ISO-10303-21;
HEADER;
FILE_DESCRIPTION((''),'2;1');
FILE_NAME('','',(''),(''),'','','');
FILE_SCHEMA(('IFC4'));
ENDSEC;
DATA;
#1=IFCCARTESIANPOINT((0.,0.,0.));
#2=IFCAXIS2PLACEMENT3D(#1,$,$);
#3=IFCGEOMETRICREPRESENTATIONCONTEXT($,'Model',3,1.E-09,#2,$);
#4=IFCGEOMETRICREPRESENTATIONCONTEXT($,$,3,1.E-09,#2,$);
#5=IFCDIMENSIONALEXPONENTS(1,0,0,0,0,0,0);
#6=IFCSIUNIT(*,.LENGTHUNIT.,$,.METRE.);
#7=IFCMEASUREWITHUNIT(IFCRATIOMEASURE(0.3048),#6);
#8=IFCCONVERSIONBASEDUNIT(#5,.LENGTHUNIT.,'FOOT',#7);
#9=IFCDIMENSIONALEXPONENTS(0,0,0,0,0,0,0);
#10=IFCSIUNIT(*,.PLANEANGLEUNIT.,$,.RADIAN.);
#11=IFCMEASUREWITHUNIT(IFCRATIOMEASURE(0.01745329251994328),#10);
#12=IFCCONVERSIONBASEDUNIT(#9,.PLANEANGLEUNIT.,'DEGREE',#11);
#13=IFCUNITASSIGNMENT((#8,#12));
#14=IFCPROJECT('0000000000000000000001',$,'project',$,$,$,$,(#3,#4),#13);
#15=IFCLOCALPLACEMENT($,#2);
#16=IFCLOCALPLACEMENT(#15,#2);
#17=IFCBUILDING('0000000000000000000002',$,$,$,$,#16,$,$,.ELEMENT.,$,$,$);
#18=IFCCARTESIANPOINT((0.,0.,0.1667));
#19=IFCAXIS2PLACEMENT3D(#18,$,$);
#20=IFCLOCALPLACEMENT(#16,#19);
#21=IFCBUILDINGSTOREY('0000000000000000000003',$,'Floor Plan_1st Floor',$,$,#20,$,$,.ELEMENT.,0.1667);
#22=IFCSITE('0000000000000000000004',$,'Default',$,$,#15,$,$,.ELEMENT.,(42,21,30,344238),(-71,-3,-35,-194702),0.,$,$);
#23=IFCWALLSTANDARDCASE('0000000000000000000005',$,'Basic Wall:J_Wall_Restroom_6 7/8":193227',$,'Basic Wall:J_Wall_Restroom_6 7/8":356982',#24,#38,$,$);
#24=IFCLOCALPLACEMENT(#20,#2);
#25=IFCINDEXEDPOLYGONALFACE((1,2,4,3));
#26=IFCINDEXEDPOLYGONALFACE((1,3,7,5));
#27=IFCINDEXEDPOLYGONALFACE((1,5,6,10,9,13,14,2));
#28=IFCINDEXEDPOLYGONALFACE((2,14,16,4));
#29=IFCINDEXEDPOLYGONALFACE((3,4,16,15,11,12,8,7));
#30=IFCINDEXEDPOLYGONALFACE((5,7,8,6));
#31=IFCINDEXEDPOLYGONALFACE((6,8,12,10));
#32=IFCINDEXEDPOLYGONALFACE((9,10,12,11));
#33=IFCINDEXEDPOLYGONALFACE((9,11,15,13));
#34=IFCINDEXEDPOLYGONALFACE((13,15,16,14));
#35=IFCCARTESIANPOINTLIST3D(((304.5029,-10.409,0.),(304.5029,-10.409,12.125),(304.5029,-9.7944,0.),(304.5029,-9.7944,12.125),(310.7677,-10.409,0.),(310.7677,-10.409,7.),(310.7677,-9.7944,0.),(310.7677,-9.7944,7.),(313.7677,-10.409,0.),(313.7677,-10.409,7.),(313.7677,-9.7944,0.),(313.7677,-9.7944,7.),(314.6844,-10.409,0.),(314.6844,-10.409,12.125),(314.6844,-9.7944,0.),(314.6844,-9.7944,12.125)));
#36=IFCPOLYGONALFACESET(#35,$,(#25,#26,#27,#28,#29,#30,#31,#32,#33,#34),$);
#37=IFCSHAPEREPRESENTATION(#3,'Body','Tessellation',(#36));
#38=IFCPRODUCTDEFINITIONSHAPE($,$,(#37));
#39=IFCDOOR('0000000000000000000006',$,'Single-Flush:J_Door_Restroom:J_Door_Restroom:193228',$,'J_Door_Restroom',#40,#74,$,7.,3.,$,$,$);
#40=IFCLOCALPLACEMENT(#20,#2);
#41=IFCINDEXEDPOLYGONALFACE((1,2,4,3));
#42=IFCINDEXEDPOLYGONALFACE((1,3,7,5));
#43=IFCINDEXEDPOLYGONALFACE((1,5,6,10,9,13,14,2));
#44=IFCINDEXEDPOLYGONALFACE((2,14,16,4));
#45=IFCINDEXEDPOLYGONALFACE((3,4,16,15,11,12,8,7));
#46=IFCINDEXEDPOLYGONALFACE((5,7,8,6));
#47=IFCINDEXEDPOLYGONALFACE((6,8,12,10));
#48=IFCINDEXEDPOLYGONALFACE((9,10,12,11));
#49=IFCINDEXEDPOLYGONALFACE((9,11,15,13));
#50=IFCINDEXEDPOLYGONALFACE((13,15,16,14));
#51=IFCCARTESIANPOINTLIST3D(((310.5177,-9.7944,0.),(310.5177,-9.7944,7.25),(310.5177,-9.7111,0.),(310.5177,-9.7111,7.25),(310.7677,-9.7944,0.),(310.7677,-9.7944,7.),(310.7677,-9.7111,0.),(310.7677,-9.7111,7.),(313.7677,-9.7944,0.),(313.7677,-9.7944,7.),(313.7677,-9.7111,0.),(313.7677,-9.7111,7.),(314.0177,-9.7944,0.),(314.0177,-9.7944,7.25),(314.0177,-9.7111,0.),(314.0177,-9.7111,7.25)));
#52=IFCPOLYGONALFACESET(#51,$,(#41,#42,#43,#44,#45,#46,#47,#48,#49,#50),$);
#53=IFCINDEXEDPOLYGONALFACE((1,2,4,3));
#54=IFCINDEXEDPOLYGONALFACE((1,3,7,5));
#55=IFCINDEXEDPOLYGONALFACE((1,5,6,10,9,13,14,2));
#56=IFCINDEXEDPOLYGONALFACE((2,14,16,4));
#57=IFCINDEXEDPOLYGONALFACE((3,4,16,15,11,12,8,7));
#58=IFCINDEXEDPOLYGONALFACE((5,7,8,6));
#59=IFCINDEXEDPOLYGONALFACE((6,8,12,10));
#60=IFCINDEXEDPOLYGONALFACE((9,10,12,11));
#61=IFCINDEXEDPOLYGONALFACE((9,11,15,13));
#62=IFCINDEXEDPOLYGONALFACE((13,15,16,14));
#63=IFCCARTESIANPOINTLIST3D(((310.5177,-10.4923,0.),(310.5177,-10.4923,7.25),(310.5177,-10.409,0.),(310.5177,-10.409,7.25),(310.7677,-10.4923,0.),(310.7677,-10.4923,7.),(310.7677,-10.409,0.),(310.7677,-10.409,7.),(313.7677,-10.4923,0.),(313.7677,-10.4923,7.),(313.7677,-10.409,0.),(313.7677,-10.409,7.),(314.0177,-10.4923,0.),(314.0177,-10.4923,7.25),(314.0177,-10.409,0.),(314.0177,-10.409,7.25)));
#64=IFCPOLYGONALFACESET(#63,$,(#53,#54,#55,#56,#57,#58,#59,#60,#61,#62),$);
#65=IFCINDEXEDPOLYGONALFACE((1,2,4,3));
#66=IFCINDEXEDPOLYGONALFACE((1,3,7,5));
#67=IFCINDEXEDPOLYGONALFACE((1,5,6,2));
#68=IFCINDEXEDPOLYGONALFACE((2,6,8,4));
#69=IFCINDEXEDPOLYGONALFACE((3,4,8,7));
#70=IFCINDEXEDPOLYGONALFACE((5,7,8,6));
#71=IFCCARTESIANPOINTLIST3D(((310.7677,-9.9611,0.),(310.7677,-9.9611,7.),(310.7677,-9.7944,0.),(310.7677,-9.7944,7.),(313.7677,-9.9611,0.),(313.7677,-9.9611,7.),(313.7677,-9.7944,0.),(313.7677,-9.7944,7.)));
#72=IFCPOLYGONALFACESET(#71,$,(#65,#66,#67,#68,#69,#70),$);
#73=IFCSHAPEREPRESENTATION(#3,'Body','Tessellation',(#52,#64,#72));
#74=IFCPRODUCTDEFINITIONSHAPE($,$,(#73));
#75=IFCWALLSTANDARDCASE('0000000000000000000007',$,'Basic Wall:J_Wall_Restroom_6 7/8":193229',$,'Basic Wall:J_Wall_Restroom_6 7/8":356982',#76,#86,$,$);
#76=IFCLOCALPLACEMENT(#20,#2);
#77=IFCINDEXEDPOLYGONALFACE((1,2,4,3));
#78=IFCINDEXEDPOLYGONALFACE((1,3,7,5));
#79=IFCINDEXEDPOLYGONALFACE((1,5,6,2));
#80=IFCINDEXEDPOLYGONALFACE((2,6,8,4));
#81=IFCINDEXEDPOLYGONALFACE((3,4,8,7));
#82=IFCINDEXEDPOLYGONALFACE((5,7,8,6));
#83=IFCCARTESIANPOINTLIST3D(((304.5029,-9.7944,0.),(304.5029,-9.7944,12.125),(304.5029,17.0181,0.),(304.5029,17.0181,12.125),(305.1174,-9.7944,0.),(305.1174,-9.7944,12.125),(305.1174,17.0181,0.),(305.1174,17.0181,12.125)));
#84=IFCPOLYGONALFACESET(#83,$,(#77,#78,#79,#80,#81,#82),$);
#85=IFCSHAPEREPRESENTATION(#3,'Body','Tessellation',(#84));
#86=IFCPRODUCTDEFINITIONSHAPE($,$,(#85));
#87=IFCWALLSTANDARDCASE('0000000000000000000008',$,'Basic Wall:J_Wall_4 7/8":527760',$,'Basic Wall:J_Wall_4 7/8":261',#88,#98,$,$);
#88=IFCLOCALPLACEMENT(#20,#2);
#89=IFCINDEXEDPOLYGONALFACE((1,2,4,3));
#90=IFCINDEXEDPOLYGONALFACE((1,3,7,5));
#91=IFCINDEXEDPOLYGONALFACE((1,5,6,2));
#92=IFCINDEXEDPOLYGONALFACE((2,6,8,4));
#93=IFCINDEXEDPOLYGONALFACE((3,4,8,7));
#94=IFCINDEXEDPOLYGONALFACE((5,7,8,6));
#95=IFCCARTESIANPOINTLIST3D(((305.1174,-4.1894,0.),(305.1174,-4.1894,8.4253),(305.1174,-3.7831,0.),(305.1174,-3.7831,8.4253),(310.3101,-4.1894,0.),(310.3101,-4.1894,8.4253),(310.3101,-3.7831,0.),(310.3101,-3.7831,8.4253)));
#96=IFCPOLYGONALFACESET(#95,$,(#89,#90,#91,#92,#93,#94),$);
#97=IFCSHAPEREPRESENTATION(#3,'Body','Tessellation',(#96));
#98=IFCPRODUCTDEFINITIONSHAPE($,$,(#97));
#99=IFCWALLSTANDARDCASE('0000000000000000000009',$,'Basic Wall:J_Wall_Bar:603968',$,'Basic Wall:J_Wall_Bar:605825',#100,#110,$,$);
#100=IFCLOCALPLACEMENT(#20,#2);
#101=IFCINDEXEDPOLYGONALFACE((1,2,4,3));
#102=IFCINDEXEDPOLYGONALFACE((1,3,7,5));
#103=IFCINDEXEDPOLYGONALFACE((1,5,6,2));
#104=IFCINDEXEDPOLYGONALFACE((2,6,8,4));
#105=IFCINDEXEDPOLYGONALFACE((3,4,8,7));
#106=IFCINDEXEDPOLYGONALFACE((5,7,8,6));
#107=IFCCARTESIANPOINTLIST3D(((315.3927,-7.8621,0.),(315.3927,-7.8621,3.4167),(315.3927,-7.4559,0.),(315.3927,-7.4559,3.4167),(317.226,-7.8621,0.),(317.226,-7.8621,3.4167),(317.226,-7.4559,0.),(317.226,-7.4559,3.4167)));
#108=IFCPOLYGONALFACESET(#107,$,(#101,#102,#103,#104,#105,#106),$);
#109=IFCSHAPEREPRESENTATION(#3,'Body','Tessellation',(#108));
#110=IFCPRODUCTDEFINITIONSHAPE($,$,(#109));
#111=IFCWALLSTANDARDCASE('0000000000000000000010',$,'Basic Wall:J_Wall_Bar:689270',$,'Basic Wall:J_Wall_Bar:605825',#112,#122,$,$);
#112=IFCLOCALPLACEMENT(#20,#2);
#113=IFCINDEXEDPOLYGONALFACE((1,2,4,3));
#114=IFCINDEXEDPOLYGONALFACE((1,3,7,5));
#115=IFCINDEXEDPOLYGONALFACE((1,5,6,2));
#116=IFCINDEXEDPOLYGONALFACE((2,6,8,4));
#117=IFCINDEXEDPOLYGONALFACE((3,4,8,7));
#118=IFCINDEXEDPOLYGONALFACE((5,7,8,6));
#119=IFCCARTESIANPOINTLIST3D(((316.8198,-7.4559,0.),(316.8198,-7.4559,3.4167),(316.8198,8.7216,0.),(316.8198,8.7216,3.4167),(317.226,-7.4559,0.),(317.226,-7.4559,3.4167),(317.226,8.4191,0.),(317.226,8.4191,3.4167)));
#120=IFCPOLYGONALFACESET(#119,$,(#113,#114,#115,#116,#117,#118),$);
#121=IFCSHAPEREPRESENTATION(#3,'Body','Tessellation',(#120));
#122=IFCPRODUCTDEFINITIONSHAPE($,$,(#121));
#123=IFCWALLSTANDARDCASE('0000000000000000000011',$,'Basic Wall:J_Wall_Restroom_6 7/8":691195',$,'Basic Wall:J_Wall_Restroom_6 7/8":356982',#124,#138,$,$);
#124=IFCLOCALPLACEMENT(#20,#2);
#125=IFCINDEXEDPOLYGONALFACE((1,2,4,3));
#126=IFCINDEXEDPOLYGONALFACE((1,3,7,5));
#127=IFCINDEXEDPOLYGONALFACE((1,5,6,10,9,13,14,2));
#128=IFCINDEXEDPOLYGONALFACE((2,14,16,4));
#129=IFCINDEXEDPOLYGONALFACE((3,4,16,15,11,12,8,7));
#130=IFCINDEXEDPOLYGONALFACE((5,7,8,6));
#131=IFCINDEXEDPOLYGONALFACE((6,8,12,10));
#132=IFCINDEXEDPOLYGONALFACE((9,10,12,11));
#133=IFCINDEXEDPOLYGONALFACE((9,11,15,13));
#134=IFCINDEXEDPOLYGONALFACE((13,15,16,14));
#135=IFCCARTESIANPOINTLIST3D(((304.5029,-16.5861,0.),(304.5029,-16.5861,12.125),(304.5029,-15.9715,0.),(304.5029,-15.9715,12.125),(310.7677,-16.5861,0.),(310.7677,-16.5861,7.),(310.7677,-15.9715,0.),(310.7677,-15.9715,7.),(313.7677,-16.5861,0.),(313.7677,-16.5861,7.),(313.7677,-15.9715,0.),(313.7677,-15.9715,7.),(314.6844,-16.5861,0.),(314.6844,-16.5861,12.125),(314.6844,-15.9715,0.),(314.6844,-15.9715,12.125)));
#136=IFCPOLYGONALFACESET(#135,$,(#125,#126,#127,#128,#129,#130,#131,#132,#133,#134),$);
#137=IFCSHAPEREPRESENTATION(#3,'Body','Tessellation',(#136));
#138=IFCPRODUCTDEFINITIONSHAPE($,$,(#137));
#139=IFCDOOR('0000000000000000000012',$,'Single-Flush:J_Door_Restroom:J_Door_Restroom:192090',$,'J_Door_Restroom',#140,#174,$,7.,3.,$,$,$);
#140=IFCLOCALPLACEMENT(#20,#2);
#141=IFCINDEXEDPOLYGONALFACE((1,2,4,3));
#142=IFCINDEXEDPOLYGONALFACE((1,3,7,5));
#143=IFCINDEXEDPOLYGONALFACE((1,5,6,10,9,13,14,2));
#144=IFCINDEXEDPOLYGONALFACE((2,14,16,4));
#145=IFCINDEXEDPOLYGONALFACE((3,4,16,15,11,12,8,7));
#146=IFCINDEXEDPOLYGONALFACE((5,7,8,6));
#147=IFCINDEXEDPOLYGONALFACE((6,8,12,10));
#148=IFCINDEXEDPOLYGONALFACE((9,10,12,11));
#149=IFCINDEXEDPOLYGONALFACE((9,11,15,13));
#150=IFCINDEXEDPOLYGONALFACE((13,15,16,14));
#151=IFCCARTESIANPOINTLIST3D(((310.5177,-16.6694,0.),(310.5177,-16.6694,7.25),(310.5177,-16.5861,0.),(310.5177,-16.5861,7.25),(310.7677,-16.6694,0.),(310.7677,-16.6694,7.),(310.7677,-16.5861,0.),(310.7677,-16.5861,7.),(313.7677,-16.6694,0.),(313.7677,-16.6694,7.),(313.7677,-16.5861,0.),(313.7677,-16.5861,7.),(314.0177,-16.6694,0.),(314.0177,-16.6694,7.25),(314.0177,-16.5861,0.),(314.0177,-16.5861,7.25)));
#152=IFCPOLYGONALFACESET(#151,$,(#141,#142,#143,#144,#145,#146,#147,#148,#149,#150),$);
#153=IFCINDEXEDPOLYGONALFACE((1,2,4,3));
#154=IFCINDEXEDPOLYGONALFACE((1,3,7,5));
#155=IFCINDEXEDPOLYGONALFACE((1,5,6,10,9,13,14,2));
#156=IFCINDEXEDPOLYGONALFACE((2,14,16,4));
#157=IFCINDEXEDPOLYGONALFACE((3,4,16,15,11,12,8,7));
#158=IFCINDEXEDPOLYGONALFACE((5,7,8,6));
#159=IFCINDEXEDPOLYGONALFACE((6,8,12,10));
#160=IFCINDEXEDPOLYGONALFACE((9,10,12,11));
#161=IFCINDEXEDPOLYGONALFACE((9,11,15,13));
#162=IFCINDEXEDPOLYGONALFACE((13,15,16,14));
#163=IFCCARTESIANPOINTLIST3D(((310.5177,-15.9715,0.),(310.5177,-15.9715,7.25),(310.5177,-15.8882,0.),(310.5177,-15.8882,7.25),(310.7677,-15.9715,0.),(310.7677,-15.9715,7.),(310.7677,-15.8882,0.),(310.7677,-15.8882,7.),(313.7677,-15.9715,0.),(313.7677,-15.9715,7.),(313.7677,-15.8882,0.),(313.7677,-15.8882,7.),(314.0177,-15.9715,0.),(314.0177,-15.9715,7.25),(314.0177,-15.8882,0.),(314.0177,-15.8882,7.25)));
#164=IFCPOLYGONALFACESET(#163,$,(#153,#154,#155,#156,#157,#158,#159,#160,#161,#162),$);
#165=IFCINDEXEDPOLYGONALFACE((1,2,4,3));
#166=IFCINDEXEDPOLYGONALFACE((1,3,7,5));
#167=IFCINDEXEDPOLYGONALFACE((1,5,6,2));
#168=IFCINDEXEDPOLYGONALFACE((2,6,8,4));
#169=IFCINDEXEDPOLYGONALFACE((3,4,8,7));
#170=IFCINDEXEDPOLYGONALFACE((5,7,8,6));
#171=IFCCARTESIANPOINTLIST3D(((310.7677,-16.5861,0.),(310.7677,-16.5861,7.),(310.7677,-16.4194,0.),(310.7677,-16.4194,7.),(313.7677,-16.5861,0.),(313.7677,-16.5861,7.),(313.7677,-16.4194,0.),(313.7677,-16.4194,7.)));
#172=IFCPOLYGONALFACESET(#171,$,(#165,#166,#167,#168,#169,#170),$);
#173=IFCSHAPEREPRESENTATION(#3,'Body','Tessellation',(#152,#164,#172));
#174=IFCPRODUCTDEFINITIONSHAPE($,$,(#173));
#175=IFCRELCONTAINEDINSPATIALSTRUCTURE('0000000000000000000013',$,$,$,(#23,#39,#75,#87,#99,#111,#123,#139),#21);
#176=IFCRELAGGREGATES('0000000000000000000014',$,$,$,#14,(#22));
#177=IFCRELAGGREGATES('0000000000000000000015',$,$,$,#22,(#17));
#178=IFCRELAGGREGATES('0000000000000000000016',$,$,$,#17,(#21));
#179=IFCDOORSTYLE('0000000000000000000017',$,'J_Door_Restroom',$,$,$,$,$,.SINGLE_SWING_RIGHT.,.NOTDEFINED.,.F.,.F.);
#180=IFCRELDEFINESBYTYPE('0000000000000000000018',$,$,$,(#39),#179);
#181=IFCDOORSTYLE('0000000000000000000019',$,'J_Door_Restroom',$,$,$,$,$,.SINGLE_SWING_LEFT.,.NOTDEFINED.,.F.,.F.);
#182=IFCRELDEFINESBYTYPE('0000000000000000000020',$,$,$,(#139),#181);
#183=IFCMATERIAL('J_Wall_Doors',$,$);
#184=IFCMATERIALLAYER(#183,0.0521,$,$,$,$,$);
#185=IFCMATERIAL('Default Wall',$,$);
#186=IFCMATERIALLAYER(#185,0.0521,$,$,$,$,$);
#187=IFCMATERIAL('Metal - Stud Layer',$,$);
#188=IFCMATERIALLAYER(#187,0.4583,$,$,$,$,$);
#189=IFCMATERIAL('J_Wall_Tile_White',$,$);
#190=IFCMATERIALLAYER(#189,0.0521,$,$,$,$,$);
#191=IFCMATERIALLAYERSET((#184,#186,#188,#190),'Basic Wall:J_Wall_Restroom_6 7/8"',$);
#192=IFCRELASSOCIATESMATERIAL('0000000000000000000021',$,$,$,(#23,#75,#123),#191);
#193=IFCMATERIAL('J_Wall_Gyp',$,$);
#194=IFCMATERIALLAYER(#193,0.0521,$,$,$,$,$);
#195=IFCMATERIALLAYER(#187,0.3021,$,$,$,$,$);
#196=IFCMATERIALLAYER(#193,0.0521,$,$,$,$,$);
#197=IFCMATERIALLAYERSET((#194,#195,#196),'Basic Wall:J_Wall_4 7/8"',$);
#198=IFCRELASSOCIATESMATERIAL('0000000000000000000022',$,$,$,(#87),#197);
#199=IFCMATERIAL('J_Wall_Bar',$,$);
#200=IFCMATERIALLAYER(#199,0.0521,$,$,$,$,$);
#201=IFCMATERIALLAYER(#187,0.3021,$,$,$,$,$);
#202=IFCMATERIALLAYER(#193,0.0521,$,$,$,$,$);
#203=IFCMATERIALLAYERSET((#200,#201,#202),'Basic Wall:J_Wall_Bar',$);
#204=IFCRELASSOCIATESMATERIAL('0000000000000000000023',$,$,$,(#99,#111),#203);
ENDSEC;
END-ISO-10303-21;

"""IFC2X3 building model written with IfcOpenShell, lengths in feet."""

from ifc_helpers import new_model, entity, si_unit, converted_unit, frame, frame_2d, origin, origin_2d_with_axis, place, context, project, spatial, polyline, rectangle, outline, extrude, clip, halfspace, source, transform, mapped, material, layer, layer_set, layer_usage, type_object, type_shapes, element, fill, save


model = new_model("IFC2X3")

# Units and contexts
model_context = context("Model", 3, precision=1e-09, world=origin())
context_of_model = context(None, 3, precision=1e-09, world=origin())
ifc_project = project(units=[converted_unit("LENGTHUNIT", "FOOT", entity("IfcRatioMeasure", 0.3048), si_unit("LENGTHUNIT", "METRE"), dimensions=[1, 0, 0, 0, 0, 0, 0]), converted_unit("PLANEANGLEUNIT", "DEGREE", entity("IfcRatioMeasure", 0.01745329251994328), si_unit("PLANEANGLEUNIT", "RADIAN"), dimensions=[0, 0, 0, 0, 0, 0, 0])], contexts=[model_context, context_of_model])

# Site, building, storey
site_placement = place(None, origin())
site = spatial("IfcSite", under=ifc_project, at=site_placement, Name="Default", CompositionType="ELEMENT", RefLatitude=(42, 21, 30, 344238), RefLongitude=(-71, -3, -35, -194702), RefElevation=0.0)
building_placement = place(site_placement, origin())
building = spatial("IfcBuilding", under=site, at=building_placement, CompositionType="ELEMENT")
storey_placement = place(building_placement, frame((0.0, 0.0, 0.1667)))
storey = spatial("IfcBuildingStorey", under=building, at=storey_placement, Name="Floor Plan_1st Floor", CompositionType="ELEMENT", Elevation=0.1667)

# Shared definitions
ifc_material_1 = material(Name="J_Wall_Doors")
ifc_layer_1 = layer(ifc_material_1, 0.0521)
ifc_material_2 = material(Name="Default Wall")
ifc_layer_2 = layer(ifc_material_2, 0.0521)
ifc_material_3 = material(Name="Metal - Stud Layer")
ifc_layer_3 = layer(ifc_material_3, 0.4583)
ifc_material_4 = material(Name="J_Wall_Tile_White")
ifc_layer_4 = layer(ifc_material_4, 0.0521)
ifc_layer_set_1 = layer_set([ifc_layer_1, ifc_layer_2, ifc_layer_3, ifc_layer_4], Name="Basic Wall:J_Wall_Restroom_6 7/8\"")

# Wall, opening, door
ifc_layer_usage_1 = layer_usage(ifc_layer_set_1, "AXIS2", "NEGATIVE", 0.3073)
wall_1_placement = place(storey_placement, frame((314.6844, -10.1017, 0.0), z_axis=(0.0, 0.0, 1.0), x_axis=(-1.0, 0.0, 0.0)))
wall_1 = element("IfcWallStandardCase", 1, at=wall_1_placement, inside=storey, material=ifc_layer_usage_1, Name="Basic Wall:J_Wall_Restroom_6 7/8\":193227", ObjectType="Basic Wall:J_Wall_Restroom_6 7/8\":356982", context=model_context, shape_type="Clipping", body=[
    clip(extrude(rectangle(XDim=10.1815, YDim=0.6146, at=frame_2d((5.0907, 0.0), x_axis=(-1.0, 0.0))), origin(), (0.0, 0.0, 1.0), 12.125), halfspace(origin(), True)),
])
opening_1_placement = place(wall_1_placement, frame((3.9167, 0.3073, 0.0)))
opening_1 = element("IfcOpeningElement", 2, at=opening_1_placement, cuts=wall_1, ObjectType="Opening", context=model_context, shape_type="SweptSolid", body=[
    extrude(rectangle(XDim=3.0, YDim=7.0, at=frame_2d((3.5, 1.5), x_axis=(0.0, 1.0))), frame((0.0, 0.0, 0.0), z_axis=(0.0, -1.0, 0.0), x_axis=(0.0, 0.0, 1.0)), (0.0, 0.0, 1.0), 0.6146),
])
door_style_1 = type_object("IfcDoorStyle", Name="J_Door_Restroom", ConstructionType="NOTDEFINED", OperationType="SINGLE_SWING_RIGHT", ParameterTakesPrecedence=False, Sizeable=False)
shared_shape_1 = source(origin(), model_context, "Body", "SweptSolid", [
    extrude(outline(polyline([(-1.75, -3.6875), (1.75, -3.6875), (1.75, 3.5625), (1.5, 3.5625), (1.5, -3.4375), (-1.5, -3.4375), (-1.5, 3.5625), (-1.75, 3.5625), (-1.75, -3.6875)])), frame((1.5, 0.6146, 3.5625), z_axis=(0.0, 1.0, 0.0), x_axis=(1.0, 0.0, 0.0)), (0.0, 0.0, 1.0), 0.0833),
    extrude(outline(polyline([(-3.6875, -1.75), (3.5625, -1.75), (3.5625, -1.5), (-3.4375, -1.5), (-3.4375, 1.5), (3.5625, 1.5), (3.5625, 1.75), (-3.6875, 1.75), (-3.6875, -1.75)])), frame((1.5, -0.0833, 3.5625), z_axis=(0.0, 1.0, 0.0), x_axis=(0.0, 0.0, -1.0)), (0.0, 0.0, 1.0), 0.0833),
    extrude(rectangle(XDim=0.1667, YDim=3.0, at=origin_2d_with_axis()), frame((1.5, 0.5313, 0.0), z_axis=(0.0, 0.0, 1.0), x_axis=(0.0, 1.0, 0.0)), (0.0, 0.0, 1.0), 7.0),
])
type_shapes(door_style_1, [shared_shape_1])
door_1_placement = place(opening_1_placement, frame((0.0, 0.0, 0.0), z_axis=(0.0, 0.0, 1.0), x_axis=(-1.0, 0.0, 0.0)))
door_1 = element("IfcDoor", 3, at=door_1_placement, inside=storey, type_object=door_style_1, Name="Single-Flush:J_Door_Restroom:J_Door_Restroom:193228", ObjectType="J_Door_Restroom", OverallHeight=7.0, OverallWidth=3.0, context=model_context, shape_type="MappedRepresentation", body=[
    mapped(shared_shape_1, transform((0.0, 0.0, 0.0), scale=1.0)),
])
fill(opening_1, door_1)

# Wall
ifc_layer_usage_2 = layer_usage(ifc_layer_set_1, "AXIS2", "NEGATIVE", 0.3073)
wall_2_placement = place(storey_placement, frame((304.8101, -9.7944, 0.0), z_axis=(0.0, 0.0, 1.0), x_axis=(0.0, 1.0, 0.0)))
element("IfcWallStandardCase", 4, at=wall_2_placement, inside=storey, material=ifc_layer_usage_2, Name="Basic Wall:J_Wall_Restroom_6 7/8\":193229", ObjectType="Basic Wall:J_Wall_Restroom_6 7/8\":356982", context=model_context, shape_type="Clipping", body=[
    clip(extrude(rectangle(XDim=26.8125, YDim=0.6146, at=frame_2d((13.4063, 0.0), x_axis=(-1.0, 0.0))), origin(), (0.0, 0.0, 1.0), 12.125), halfspace(origin(), True)),
])

# Shared definitions
ifc_material_5 = material(Name="J_Wall_Gyp")
ifc_layer_5 = layer(ifc_material_5, 0.0521)
ifc_layer_6 = layer(ifc_material_3, 0.3021)
ifc_layer_7 = layer(ifc_material_5, 0.0521)
ifc_layer_set_2 = layer_set([ifc_layer_5, ifc_layer_6, ifc_layer_7], Name="Basic Wall:J_Wall_4 7/8\"")

# Walls
ifc_layer_usage_3 = layer_usage(ifc_layer_set_2, "AXIS2", "NEGATIVE", 0.2031)
wall_3_placement = place(storey_placement, frame((305.1174, -3.9863, 0.0)))
element("IfcWallStandardCase", 5, at=wall_3_placement, inside=storey, material=ifc_layer_usage_3, Name="Basic Wall:J_Wall_4 7/8\":527760", ObjectType="Basic Wall:J_Wall_4 7/8\":261", context=model_context, shape_type="SweptSolid", body=[
    extrude(rectangle(XDim=5.1927, YDim=0.4062, at=frame_2d((2.5964, 0.0), x_axis=(-1.0, 0.0))), origin(), (0.0, 0.0, 1.0), 8.4253),
])
ifc_material_6 = material(Name="J_Wall_Bar")
ifc_layer_8 = layer(ifc_material_6, 0.0521)
ifc_layer_9 = layer(ifc_material_3, 0.3021)
ifc_layer_10 = layer(ifc_material_5, 0.0521)
ifc_layer_set_3 = layer_set([ifc_layer_8, ifc_layer_9, ifc_layer_10], Name="Basic Wall:J_Wall_Bar")
ifc_layer_usage_4 = layer_usage(ifc_layer_set_3, "AXIS2", "POSITIVE", -0.2031)
wall_4_placement = place(storey_placement, frame((315.3927, -7.659, 0.0)))
element("IfcWallStandardCase", 6, at=wall_4_placement, inside=storey, material=ifc_layer_usage_4, Name="Basic Wall:J_Wall_Bar:603968", ObjectType="Basic Wall:J_Wall_Bar:605825", context=model_context, shape_type="SweptSolid", body=[
    extrude(rectangle(XDim=1.8333, YDim=0.4062, at=frame_2d((0.9167, 0.0), x_axis=(-1.0, 0.0))), origin(), (0.0, 0.0, 1.0), 3.4167),
])
ifc_layer_usage_5 = layer_usage(ifc_layer_set_3, "AXIS2", "POSITIVE", -0.2031)
wall_5_placement = place(storey_placement, frame((317.0229, -7.4559, 0.0), z_axis=(0.0, 0.0, 1.0), x_axis=(0.0, 1.0, 0.0)))
element("IfcWallStandardCase", 7, at=wall_5_placement, inside=storey, material=ifc_layer_usage_5, Name="Basic Wall:J_Wall_Bar:689270", ObjectType="Basic Wall:J_Wall_Bar:605825", context=model_context, shape_type="SweptSolid", body=[
    extrude(outline(polyline([(15.8749, -0.2031), (16.1775, 0.2031), (0.0, 0.2031), (0.0, -0.2031), (15.8749, -0.2031)])), origin(), (0.0, 0.0, 1.0), 3.4167),
])

# Wall, opening, door
ifc_layer_usage_6 = layer_usage(ifc_layer_set_1, "AXIS2", "POSITIVE", -0.3073)
wall_6_placement = place(storey_placement, frame((314.6844, -16.2788, 0.0), z_axis=(0.0, 0.0, 1.0), x_axis=(-1.0, 0.0, 0.0)))
wall_6 = element("IfcWallStandardCase", 8, at=wall_6_placement, inside=storey, material=ifc_layer_usage_6, Name="Basic Wall:J_Wall_Restroom_6 7/8\":691195", ObjectType="Basic Wall:J_Wall_Restroom_6 7/8\":356982", context=model_context, shape_type="Clipping", body=[
    clip(extrude(rectangle(XDim=10.1815, YDim=0.6146, at=frame_2d((5.0907, 0.0), x_axis=(-1.0, 0.0))), origin(), (0.0, 0.0, 1.0), 12.125), halfspace(origin(), True)),
])
opening_2_placement = place(wall_6_placement, frame((0.9167, -0.3073, 0.0)))
opening_2 = element("IfcOpeningElement", 9, at=opening_2_placement, cuts=wall_6, ObjectType="Opening", context=model_context, shape_type="SweptSolid", body=[
    extrude(rectangle(XDim=3.0, YDim=7.0, at=frame_2d((3.5, 1.5), x_axis=(0.0, -1.0))), frame((0.0, 0.0, 0.0), z_axis=(0.0, 1.0, 0.0), x_axis=(0.0, 0.0, 1.0)), (0.0, 0.0, 1.0), 0.6146),
])
door_style_2 = type_object("IfcDoorStyle", Name="J_Door_Restroom", ConstructionType="NOTDEFINED", OperationType="SINGLE_SWING_LEFT", ParameterTakesPrecedence=False, Sizeable=False)
shared_shape_2 = source(origin(), model_context, "Body", "SweptSolid", [
    extrude(outline(polyline([(-1.75, -3.6875), (1.75, -3.6875), (1.75, 3.5625), (1.5, 3.5625), (1.5, -3.4375), (-1.5, -3.4375), (-1.5, 3.5625), (-1.75, 3.5625), (-1.75, -3.6875)])), frame((1.5, 0.6979, 3.5625), z_axis=(0.0, -1.0, 0.0), x_axis=(-1.0, 0.0, 0.0)), (0.0, 0.0, 1.0), 0.0833),
    extrude(outline(polyline([(-3.6875, -1.75), (3.5625, -1.75), (3.5625, -1.5), (-3.4375, -1.5), (-3.4375, 1.5), (3.5625, 1.5), (3.5625, 1.75), (-3.6875, 1.75), (-3.6875, -1.75)])), frame((1.5, 0.0, 3.5625), z_axis=(0.0, -1.0, 0.0), x_axis=(0.0, 0.0, -1.0)), (0.0, 0.0, 1.0), 0.0833),
    extrude(rectangle(XDim=3.0, YDim=0.1667, at=origin_2d_with_axis()), frame((1.5, 0.5312, 0.0)), (0.0, 0.0, 1.0), 7.0),
])
type_shapes(door_style_2, [shared_shape_2])
door_2_placement = place(opening_2_placement, origin())
door_2 = element("IfcDoor", 10, at=door_2_placement, inside=storey, type_object=door_style_2, Name="Single-Flush:J_Door_Restroom:J_Door_Restroom:192090", ObjectType="J_Door_Restroom", OverallHeight=7.0, OverallWidth=3.0, context=model_context, shape_type="MappedRepresentation", body=[
    mapped(shared_shape_2, transform((0.0, 0.0, 0.0), scale=1.0)),
])
fill(opening_2, door_2)

save(model, "model.ifc")
